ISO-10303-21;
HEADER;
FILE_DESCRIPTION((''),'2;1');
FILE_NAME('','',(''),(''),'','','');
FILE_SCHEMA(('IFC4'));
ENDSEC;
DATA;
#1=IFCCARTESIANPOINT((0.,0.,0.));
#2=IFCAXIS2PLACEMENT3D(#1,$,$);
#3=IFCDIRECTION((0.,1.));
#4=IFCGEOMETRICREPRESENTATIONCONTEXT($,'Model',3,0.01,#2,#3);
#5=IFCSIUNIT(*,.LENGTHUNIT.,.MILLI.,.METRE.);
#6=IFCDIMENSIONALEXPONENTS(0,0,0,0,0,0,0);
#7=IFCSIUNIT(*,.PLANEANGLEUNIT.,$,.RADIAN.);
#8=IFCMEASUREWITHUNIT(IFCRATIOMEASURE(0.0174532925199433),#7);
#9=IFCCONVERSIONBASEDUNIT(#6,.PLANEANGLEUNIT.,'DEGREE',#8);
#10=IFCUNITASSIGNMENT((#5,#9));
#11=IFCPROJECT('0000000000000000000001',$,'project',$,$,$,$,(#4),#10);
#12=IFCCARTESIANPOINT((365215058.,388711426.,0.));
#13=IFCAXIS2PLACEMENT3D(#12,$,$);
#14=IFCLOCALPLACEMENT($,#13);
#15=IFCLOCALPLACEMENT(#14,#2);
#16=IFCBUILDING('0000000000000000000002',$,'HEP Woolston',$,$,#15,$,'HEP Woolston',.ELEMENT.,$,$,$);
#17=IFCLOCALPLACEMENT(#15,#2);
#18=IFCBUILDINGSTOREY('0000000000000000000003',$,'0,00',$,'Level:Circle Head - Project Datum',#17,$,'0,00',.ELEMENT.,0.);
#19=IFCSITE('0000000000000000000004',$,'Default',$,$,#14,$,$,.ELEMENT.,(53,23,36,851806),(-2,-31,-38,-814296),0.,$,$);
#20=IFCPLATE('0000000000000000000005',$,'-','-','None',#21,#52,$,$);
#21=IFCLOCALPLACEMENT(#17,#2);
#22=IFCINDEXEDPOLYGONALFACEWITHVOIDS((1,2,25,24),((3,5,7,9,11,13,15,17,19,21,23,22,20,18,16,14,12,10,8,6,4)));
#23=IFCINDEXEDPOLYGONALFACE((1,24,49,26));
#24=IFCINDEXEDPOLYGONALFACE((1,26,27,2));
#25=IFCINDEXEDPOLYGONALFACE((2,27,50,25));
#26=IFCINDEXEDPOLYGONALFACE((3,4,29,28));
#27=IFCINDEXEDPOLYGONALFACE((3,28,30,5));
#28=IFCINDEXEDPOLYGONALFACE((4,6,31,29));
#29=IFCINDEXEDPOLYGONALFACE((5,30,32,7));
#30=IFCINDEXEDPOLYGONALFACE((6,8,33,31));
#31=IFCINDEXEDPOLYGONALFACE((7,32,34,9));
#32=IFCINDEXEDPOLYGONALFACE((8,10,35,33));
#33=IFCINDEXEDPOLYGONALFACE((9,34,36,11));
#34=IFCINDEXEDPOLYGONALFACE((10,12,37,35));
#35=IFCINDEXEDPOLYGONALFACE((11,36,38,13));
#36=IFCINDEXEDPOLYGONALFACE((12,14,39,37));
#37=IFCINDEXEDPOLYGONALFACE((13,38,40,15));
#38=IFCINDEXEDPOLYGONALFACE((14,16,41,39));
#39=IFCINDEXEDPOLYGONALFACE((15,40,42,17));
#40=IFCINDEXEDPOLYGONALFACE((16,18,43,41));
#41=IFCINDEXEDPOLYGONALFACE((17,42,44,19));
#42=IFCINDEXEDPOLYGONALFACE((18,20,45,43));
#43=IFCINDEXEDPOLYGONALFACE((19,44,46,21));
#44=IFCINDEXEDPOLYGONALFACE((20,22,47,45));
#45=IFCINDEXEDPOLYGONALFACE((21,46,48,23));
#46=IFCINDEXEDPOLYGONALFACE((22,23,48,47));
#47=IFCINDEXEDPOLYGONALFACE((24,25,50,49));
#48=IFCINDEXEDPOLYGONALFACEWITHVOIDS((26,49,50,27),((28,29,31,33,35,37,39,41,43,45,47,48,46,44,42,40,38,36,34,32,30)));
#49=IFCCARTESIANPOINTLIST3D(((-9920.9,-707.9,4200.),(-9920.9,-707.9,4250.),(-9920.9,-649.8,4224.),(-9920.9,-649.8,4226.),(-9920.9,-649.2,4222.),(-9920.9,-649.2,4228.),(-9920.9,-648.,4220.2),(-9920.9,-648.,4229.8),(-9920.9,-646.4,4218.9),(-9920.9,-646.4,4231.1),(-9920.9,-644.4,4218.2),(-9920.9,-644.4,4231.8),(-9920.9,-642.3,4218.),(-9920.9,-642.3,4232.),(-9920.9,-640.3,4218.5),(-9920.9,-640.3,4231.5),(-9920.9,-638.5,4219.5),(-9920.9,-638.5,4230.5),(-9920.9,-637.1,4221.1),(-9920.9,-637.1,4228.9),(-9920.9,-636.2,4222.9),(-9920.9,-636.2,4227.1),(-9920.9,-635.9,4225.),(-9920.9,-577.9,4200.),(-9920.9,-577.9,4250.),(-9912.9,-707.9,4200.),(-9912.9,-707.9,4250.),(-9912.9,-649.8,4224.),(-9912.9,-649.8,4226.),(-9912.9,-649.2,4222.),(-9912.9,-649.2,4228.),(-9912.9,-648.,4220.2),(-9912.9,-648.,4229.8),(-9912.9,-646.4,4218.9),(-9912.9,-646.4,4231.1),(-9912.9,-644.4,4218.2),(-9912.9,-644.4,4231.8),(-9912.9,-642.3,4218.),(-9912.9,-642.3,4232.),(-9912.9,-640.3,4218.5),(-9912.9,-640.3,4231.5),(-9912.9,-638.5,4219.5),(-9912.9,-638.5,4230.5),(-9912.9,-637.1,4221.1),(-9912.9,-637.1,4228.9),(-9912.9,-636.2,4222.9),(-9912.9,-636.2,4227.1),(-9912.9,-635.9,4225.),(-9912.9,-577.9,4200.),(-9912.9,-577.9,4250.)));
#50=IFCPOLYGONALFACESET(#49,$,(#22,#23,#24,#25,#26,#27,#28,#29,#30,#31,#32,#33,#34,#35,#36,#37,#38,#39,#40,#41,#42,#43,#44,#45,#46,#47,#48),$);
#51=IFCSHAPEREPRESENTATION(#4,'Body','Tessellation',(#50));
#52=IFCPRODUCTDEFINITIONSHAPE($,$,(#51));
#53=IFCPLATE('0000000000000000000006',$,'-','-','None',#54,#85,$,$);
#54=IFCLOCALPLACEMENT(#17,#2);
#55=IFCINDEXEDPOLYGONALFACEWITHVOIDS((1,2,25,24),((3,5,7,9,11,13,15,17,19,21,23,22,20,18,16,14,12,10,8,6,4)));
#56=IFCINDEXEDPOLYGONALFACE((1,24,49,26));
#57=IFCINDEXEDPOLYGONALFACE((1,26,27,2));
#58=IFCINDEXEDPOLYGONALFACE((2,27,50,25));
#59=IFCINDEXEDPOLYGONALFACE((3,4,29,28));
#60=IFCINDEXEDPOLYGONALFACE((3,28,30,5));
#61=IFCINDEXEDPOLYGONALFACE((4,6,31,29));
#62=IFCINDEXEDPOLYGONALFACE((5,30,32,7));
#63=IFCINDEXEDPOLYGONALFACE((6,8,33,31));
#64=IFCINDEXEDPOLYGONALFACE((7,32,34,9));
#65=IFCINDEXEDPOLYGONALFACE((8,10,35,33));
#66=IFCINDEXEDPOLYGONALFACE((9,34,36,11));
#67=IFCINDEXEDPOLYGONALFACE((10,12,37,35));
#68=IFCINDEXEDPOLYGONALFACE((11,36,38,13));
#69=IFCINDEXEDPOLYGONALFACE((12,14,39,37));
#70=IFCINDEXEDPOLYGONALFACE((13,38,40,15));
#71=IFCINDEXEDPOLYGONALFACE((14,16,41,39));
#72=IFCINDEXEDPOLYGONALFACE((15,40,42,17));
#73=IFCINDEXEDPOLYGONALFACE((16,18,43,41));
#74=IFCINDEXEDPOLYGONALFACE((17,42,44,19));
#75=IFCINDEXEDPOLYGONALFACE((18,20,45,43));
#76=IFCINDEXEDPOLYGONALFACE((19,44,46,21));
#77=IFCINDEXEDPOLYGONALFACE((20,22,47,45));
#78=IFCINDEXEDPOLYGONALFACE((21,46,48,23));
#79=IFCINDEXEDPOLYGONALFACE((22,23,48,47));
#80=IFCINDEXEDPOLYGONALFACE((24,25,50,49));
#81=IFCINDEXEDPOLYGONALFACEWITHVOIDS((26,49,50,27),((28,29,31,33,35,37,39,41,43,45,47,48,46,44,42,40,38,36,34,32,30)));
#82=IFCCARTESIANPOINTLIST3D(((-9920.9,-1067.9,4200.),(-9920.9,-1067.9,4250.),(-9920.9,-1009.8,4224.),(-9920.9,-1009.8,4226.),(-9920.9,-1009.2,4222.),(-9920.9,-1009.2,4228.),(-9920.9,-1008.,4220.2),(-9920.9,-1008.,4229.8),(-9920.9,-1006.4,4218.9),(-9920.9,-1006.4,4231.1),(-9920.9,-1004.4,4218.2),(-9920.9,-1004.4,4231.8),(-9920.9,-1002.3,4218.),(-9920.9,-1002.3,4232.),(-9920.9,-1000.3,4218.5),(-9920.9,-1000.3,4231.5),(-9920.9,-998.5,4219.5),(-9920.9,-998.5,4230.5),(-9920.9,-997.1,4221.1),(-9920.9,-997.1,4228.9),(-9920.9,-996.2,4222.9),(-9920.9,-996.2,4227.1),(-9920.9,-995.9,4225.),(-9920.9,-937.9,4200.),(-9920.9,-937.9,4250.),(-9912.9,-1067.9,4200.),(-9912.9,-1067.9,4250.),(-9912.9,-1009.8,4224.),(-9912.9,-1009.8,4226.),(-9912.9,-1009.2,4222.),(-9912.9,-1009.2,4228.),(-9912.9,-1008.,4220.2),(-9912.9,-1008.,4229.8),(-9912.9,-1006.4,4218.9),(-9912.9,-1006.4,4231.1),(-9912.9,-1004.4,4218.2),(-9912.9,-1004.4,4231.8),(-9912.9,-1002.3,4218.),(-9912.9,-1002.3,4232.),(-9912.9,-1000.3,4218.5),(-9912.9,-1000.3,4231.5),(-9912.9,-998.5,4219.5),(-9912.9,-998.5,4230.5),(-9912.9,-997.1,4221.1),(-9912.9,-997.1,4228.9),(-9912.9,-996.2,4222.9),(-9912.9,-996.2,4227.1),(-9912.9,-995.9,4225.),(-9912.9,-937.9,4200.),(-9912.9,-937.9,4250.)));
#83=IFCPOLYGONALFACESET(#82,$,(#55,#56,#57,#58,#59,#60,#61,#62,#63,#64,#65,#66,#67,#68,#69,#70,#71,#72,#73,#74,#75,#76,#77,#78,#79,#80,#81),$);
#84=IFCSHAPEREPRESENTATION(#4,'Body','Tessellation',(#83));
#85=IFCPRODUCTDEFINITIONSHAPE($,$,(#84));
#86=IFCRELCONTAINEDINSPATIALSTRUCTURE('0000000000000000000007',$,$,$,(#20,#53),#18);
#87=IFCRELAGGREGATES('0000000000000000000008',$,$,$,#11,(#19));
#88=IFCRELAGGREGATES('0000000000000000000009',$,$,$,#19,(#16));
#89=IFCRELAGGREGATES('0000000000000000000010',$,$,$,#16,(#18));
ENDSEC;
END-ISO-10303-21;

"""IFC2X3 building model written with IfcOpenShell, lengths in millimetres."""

from ifc_helpers import new_model, entity, si_unit, converted_unit, direction, frame, origin, origin_with_axes, origin_2d_with_axis, place, context, project, spatial, polyline, circle, outline, extrude, element, save


model = new_model("IFC2X3")

# Units and contexts
model_context = context("Model", 3, precision=0.01, world=origin(), true_north=direction((0.0, 1.0)))
ifc_project = project(units=[si_unit("LENGTHUNIT", "METRE", prefix="MILLI"), converted_unit("PLANEANGLEUNIT", "DEGREE", entity("IfcRatioMeasure", 0.0174532925199433), si_unit("PLANEANGLEUNIT", "RADIAN"), dimensions=[0, 0, 0, 0, 0, 0, 0])], contexts=[model_context])

# Site, building, storey
site_placement = place(None, frame((365215058.0, 388711426.0, 0.0)))
site = spatial("IfcSite", under=ifc_project, at=site_placement, Name="Default", CompositionType="ELEMENT", RefLatitude=(53, 23, 36, 851806), RefLongitude=(-2, -31, -38, -814296), RefElevation=0.0)
building_placement = place(site_placement, origin())
building = spatial("IfcBuilding", under=site, at=building_placement, Name="HEP Woolston", LongName="HEP Woolston", CompositionType="ELEMENT")
storey_placement = place(building_placement, origin())
storey = spatial("IfcBuildingStorey", under=building, at=storey_placement, Name="0,00", ObjectType="Level:Circle Head - Project Datum", LongName="0,00", CompositionType="ELEMENT", Elevation=0.0)

# Plates, openings
plate_1_placement = place(storey_placement, frame((-9920.9, -707.9, 4250.0), z_axis=(1.0, 0.0, 0.0), x_axis=(0.0, 1.0, 0.0)))
plate_1 = element("IfcPlate", 1, at=plate_1_placement, inside=storey, Name="-", Description="-", ObjectType="None", context=model_context, shape_type="SweptSolid", body=[
    extrude(outline(polyline([(0.0, -50.0), (130.0, -50.0), (130.0, 0.0), (0.0, 0.0), (0.0, -50.0)])), origin_with_axes(), (0.0, 0.0, 1.0), 8.0),
])
opening_1_placement = place(plate_1_placement, frame((65.0, -25.0, 8.5), z_axis=(0.0, 0.0, -1.0), x_axis=(1.0, 0.0, 0.0)))
element("IfcOpeningElement", 2, at=opening_1_placement, cuts=plate_1, ObjectType="Opening", context=model_context, shape_type="SweptSolid", body=[
    extrude(circle(Radius=7.0, at=origin_2d_with_axis()), origin(), (0.0, 0.0, 1.0), 9.0),
])
plate_2_placement = place(storey_placement, frame((-9920.9, -1067.9, 4250.0), z_axis=(1.0, 0.0, 0.0), x_axis=(0.0, 1.0, 0.0)))
plate_2 = element("IfcPlate", 3, at=plate_2_placement, inside=storey, Name="-", Description="-", ObjectType="None", context=model_context, shape_type="SweptSolid", body=[
    extrude(outline(polyline([(0.0, -50.0), (130.0, -50.0), (130.0, 0.0), (0.0, 0.0), (0.0, -50.0)])), origin_with_axes(), (0.0, 0.0, 1.0), 8.0),
])
opening_2_placement = place(plate_2_placement, frame((65.0, -25.0, 8.5), z_axis=(0.0, 0.0, -1.0), x_axis=(1.0, 0.0, 0.0)))
element("IfcOpeningElement", 4, at=opening_2_placement, cuts=plate_2, ObjectType="Opening", context=model_context, shape_type="SweptSolid", body=[
    extrude(circle(Radius=7.0, at=origin_2d_with_axis()), origin(), (0.0, 0.0, 1.0), 9.0),
])

save(model, "model.ifc")
